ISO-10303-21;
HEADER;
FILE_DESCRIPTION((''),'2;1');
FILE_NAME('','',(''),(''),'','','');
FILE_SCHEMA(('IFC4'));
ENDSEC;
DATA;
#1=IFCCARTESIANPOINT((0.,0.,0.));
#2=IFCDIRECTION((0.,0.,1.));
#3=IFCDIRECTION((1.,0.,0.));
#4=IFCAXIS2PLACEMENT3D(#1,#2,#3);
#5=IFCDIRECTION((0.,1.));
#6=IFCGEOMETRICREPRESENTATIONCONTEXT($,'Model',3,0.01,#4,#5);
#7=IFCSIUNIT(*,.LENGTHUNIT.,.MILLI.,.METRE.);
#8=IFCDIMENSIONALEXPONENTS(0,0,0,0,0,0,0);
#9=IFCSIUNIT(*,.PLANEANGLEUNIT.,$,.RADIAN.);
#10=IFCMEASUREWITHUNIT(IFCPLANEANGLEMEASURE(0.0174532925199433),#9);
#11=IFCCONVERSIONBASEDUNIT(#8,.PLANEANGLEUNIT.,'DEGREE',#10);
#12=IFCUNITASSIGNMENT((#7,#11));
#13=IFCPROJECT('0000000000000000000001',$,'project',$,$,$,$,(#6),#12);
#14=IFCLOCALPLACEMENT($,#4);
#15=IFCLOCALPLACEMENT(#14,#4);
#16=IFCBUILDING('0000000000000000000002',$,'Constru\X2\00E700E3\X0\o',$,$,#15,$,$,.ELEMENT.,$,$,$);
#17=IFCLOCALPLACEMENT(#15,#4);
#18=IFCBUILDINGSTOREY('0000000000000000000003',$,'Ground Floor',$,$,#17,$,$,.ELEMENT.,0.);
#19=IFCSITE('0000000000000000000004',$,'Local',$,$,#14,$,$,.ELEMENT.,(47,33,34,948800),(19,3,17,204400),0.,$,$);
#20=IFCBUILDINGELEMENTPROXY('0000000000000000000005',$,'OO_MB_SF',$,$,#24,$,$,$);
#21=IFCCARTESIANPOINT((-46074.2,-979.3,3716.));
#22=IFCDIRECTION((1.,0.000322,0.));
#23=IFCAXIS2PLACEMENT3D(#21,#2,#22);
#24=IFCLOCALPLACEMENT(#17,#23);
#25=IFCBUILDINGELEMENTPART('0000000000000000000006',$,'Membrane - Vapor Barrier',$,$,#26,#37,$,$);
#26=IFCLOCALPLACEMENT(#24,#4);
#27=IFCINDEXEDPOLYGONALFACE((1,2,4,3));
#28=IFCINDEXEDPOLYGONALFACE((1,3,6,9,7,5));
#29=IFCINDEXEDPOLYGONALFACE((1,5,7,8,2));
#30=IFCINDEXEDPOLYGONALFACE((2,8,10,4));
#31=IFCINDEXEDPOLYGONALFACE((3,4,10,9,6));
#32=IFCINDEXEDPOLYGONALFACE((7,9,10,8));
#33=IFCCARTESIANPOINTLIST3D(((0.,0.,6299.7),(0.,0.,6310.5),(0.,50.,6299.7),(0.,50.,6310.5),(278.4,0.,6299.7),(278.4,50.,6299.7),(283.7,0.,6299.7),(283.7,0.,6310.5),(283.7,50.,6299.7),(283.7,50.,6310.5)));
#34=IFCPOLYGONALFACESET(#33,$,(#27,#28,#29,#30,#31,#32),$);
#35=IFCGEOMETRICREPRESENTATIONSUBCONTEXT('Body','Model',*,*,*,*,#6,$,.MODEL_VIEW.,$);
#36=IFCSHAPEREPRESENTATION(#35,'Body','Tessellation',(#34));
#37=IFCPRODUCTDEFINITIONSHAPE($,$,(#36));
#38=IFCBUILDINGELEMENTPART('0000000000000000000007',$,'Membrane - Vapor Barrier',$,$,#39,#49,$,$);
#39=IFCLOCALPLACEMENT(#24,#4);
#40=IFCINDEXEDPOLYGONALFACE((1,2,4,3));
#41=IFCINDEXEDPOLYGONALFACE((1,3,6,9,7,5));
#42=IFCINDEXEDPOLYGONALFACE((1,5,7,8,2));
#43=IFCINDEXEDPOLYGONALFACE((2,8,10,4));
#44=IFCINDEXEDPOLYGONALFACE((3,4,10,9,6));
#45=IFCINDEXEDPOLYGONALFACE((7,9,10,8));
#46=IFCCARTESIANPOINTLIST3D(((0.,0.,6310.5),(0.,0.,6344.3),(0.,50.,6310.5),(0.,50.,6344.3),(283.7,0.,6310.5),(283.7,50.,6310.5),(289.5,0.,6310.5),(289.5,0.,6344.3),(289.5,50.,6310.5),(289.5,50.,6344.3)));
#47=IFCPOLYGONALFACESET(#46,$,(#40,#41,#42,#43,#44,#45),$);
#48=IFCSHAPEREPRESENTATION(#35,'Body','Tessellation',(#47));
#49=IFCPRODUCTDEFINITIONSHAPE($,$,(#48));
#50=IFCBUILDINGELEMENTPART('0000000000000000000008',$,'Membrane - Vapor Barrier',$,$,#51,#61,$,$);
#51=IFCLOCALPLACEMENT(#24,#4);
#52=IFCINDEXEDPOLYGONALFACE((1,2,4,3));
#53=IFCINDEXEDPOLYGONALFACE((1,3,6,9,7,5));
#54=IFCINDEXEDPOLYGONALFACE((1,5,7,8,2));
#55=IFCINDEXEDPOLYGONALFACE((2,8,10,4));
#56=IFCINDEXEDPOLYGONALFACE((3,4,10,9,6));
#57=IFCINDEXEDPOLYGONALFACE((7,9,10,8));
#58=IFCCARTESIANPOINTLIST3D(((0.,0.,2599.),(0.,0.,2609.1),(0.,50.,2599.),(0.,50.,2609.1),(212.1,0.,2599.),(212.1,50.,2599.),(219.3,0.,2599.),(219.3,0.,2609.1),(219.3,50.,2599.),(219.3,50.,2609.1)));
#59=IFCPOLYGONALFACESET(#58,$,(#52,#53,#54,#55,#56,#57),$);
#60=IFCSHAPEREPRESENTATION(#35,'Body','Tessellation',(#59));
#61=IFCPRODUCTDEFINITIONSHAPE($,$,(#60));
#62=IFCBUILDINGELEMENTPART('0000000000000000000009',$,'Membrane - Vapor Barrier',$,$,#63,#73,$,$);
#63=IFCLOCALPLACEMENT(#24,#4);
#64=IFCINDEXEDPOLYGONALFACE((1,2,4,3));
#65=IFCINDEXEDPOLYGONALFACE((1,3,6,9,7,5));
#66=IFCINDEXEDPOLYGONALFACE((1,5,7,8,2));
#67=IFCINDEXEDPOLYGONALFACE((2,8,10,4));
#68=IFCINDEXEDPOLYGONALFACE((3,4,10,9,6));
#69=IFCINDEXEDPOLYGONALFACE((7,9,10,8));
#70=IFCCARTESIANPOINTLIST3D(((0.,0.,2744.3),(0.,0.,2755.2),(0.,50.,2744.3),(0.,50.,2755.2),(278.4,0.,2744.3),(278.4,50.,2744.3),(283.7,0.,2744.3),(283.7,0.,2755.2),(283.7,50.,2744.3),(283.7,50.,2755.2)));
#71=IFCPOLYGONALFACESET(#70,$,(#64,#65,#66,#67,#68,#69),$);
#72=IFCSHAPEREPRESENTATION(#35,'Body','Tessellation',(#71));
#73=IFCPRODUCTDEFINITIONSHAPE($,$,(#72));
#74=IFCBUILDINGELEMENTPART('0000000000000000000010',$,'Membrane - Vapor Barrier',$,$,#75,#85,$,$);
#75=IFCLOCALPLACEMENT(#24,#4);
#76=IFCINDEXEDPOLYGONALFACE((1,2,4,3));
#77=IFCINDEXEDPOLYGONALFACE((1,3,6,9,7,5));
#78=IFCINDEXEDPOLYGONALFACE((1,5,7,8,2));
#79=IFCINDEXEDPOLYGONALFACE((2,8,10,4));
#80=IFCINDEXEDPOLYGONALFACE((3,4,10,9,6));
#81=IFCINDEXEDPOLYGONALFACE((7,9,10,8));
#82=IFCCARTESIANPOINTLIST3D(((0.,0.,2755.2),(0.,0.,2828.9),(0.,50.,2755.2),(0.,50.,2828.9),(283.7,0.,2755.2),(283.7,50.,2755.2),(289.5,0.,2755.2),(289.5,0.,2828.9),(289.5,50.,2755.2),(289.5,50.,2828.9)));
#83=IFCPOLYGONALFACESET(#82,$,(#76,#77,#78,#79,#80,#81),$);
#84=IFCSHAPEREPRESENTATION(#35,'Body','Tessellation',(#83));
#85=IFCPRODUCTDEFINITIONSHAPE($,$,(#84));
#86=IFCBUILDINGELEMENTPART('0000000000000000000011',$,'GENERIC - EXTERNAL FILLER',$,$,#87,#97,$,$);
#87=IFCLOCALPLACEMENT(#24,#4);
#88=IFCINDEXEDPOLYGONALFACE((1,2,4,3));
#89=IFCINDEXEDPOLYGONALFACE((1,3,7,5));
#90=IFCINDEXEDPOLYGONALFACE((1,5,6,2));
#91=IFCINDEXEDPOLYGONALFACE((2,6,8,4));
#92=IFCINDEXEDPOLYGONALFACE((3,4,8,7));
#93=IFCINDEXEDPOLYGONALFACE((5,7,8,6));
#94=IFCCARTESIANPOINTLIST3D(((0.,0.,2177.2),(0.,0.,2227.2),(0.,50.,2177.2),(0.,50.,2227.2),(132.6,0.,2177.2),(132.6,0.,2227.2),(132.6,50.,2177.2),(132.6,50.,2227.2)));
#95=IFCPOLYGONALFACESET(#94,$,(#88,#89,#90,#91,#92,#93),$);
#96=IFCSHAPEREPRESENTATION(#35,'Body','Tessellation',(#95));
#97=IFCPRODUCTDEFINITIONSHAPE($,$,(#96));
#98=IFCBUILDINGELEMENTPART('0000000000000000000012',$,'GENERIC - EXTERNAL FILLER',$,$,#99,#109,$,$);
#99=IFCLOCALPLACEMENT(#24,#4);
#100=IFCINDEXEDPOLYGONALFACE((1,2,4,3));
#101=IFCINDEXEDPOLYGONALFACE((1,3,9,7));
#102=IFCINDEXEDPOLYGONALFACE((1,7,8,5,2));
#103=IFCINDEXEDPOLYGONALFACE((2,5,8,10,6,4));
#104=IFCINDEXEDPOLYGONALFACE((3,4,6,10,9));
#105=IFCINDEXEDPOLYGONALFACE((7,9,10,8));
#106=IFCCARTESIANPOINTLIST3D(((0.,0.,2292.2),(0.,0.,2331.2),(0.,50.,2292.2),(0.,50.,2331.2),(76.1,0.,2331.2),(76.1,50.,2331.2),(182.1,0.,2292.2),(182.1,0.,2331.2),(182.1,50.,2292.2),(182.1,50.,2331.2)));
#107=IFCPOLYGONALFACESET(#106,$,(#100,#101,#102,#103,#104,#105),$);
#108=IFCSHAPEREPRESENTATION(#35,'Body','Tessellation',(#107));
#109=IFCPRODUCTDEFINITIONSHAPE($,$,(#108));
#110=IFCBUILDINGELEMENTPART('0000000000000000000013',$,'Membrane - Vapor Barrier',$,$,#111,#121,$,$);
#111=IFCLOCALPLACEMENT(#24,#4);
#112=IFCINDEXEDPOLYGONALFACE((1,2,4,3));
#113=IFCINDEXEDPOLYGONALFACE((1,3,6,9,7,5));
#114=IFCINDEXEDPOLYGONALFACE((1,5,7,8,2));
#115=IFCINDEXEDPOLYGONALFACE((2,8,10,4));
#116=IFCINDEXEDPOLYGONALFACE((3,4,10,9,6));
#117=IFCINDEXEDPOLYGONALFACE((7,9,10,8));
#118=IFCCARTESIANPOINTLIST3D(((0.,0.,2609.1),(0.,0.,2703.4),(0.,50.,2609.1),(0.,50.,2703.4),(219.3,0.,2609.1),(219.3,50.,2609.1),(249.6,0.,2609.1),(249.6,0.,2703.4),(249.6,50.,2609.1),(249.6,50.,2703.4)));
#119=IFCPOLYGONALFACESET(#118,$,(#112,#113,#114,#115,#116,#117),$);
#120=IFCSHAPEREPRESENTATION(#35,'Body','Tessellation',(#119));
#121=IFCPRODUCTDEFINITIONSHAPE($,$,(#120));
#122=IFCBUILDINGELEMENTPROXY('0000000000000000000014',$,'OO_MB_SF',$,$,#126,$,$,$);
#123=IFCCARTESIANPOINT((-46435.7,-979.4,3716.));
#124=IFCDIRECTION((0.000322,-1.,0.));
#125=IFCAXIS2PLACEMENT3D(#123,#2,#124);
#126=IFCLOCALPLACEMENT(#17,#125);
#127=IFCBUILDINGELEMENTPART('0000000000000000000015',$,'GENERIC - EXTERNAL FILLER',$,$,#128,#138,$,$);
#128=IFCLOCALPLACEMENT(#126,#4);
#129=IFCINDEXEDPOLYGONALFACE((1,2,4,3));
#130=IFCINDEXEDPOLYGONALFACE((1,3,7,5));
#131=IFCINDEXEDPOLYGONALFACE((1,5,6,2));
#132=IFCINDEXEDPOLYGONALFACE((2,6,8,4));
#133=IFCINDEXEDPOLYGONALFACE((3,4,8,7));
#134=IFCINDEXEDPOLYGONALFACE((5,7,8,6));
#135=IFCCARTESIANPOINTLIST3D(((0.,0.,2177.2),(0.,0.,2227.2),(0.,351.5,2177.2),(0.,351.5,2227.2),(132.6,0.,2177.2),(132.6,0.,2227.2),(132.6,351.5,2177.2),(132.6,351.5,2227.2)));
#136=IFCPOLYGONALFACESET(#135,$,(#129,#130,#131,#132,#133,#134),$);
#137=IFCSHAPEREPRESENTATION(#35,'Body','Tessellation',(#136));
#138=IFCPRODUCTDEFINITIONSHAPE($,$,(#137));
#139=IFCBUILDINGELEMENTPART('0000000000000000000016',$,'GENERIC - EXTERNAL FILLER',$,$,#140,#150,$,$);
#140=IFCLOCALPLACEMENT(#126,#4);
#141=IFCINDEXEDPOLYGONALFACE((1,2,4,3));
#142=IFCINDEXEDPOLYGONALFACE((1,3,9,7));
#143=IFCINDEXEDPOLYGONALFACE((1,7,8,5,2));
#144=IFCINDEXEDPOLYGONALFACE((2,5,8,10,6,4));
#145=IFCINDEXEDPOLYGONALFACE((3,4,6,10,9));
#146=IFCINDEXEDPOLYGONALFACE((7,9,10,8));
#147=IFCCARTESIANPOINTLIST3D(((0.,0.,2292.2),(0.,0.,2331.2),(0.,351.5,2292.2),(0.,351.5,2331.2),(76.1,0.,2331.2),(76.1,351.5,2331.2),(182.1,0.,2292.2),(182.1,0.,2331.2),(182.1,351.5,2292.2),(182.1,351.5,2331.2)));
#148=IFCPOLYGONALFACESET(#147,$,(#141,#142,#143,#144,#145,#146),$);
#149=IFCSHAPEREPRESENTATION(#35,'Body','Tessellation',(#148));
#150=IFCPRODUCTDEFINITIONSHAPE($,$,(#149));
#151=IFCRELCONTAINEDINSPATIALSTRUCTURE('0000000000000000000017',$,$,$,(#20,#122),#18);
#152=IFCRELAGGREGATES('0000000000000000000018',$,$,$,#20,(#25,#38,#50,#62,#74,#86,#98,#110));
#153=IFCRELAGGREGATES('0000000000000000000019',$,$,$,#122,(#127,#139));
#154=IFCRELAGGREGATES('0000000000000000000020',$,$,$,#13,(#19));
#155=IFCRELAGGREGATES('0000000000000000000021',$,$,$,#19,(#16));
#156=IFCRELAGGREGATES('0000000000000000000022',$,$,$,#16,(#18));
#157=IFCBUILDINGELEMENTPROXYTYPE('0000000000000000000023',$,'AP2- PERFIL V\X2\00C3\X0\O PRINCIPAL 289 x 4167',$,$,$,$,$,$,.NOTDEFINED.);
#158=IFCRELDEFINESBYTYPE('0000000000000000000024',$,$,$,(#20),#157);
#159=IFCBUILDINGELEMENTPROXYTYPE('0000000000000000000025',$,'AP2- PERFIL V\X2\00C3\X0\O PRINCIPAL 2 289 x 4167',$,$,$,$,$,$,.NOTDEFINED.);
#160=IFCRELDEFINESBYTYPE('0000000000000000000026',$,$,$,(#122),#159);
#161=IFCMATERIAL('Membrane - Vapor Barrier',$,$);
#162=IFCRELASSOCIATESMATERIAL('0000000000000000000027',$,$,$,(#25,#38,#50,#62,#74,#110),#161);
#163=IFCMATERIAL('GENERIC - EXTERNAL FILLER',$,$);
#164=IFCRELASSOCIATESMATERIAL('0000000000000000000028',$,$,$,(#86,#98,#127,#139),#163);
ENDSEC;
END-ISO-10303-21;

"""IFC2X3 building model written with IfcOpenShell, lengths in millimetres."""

from ifc_helpers import new_model, entity, si_unit, converted_unit, direction, frame, origin_with_axes, place, context, subcontext, project, spatial, polyline, outline, extrude, material, type_object, element, aggregate, save


model = new_model("IFC2X3")

# Units and contexts
model_context = context("Model", 3, precision=0.01, world=origin_with_axes(), true_north=direction((0.0, 1.0)))
body_context = subcontext(model_context, "Body", "Model", "MODEL_VIEW")
ifc_project = project(units=[si_unit("LENGTHUNIT", "METRE", prefix="MILLI"), converted_unit("PLANEANGLEUNIT", "DEGREE", entity("IfcPlaneAngleMeasure", 0.0174532925199433), si_unit("PLANEANGLEUNIT", "RADIAN"), dimensions=[0, 0, 0, 0, 0, 0, 0])], contexts=[model_context])

# Site, building, storey
site_placement = place(None, origin_with_axes())
site = spatial("IfcSite", under=ifc_project, at=site_placement, Name="Local", CompositionType="ELEMENT", RefLatitude=(47, 33, 34, 948800), RefLongitude=(19, 3, 17, 204400), RefElevation=0.0)
building_placement = place(site_placement, origin_with_axes())
building = spatial("IfcBuilding", under=site, at=building_placement, Name="Construção", CompositionType="ELEMENT")
storey_placement = place(building_placement, origin_with_axes())
storey = spatial("IfcBuildingStorey", under=building, at=storey_placement, Name="Ground Floor", CompositionType="ELEMENT", Elevation=0.0)

# Building element proxies, building element parts
building_element_proxy_type_1 = type_object("IfcBuildingElementProxyType", Name="AP2- PERFIL VÃO PRINCIPAL 289 x 4167", PredefinedType="NOTDEFINED")
ifc_material_1 = material(Name="Membrane - Vapor Barrier")
ifc_material_2 = material(Name="GENERIC - EXTERNAL FILLER")
proxy_1_placement = place(storey_placement, frame((-46074.2, -979.3, 3716.0), z_axis=(0.0, 0.0, 1.0), x_axis=(1.0, 0.000322, 0.0)))
proxy_1 = element("IfcBuildingElementProxy", 1, at=proxy_1_placement, inside=storey, type_object=building_element_proxy_type_1, Name="OO_MB_SF")
building_element_part_1_placement = place(proxy_1_placement, origin_with_axes())
building_element_part_1 = element("IfcBuildingElementPart", 2, at=building_element_part_1_placement, material=ifc_material_1, Name="Membrane - Vapor Barrier", context=body_context, shape_type="SweptSolid", body=[
    extrude(outline(polyline([(0.0, 6299.7), (278.4, 6299.7), (283.7, 6299.7), (283.7, 6310.5), (0.0, 6310.5), (0.0, 6299.7)])), frame((0.0, 50.0, 0.0), z_axis=(0.0, -1.0, 0.0), x_axis=(1.0, 0.0, 0.0)), (0.0, 0.0, 1.0), 50.0),
])
building_element_part_2_placement = place(proxy_1_placement, origin_with_axes())
building_element_part_2 = element("IfcBuildingElementPart", 3, at=building_element_part_2_placement, material=ifc_material_1, Name="Membrane - Vapor Barrier", context=body_context, shape_type="SweptSolid", body=[
    extrude(outline(polyline([(0.0, 6310.5), (283.7, 6310.5), (289.5, 6310.5), (289.5, 6344.3), (0.0, 6344.3), (0.0, 6310.5)])), frame((0.0, 50.0, 0.0), z_axis=(0.0, -1.0, 0.0), x_axis=(1.0, 0.0, 0.0)), (0.0, 0.0, 1.0), 50.0),
])
building_element_part_3_placement = place(proxy_1_placement, origin_with_axes())
building_element_part_3 = element("IfcBuildingElementPart", 4, at=building_element_part_3_placement, material=ifc_material_1, Name="Membrane - Vapor Barrier", context=body_context, shape_type="SweptSolid", body=[
    extrude(outline(polyline([(0.0, 2599.0), (212.1, 2599.0), (219.3, 2599.0), (219.3, 2609.1), (0.0, 2609.1), (0.0, 2599.0)])), frame((0.0, 50.0, 0.0), z_axis=(0.0, -1.0, 0.0), x_axis=(1.0, 0.0, 0.0)), (0.0, 0.0, 1.0), 50.0),
])
building_element_part_4_placement = place(proxy_1_placement, origin_with_axes())
building_element_part_4 = element("IfcBuildingElementPart", 5, at=building_element_part_4_placement, material=ifc_material_1, Name="Membrane - Vapor Barrier", context=body_context, shape_type="SweptSolid", body=[
    extrude(outline(polyline([(0.0, 2744.3), (278.4, 2744.3), (283.7, 2744.3), (283.7, 2755.2), (0.0, 2755.2), (0.0, 2744.3)])), frame((0.0, 50.0, 0.0), z_axis=(0.0, -1.0, 0.0), x_axis=(1.0, 0.0, 0.0)), (0.0, 0.0, 1.0), 50.0),
])
building_element_part_5_placement = place(proxy_1_placement, origin_with_axes())
building_element_part_5 = element("IfcBuildingElementPart", 6, at=building_element_part_5_placement, material=ifc_material_1, Name="Membrane - Vapor Barrier", context=body_context, shape_type="SweptSolid", body=[
    extrude(outline(polyline([(0.0, 2755.2), (283.7, 2755.2), (289.5, 2755.2), (289.5, 2828.9), (0.0, 2828.9), (0.0, 2755.2)])), frame((0.0, 50.0, 0.0), z_axis=(0.0, -1.0, 0.0), x_axis=(1.0, 0.0, 0.0)), (0.0, 0.0, 1.0), 50.0),
])
building_element_part_6_placement = place(proxy_1_placement, origin_with_axes())
building_element_part_6 = element("IfcBuildingElementPart", 7, at=building_element_part_6_placement, material=ifc_material_2, Name="GENERIC - EXTERNAL FILLER", context=body_context, shape_type="SweptSolid", body=[
    extrude(outline(polyline([(0.0, 2227.2), (0.0, 2177.2), (132.6, 2177.2), (132.6, 2227.2), (0.0, 2227.2)])), frame((0.0, 50.0, 0.0), z_axis=(0.0, -1.0, 0.0), x_axis=(1.0, 0.0, 0.0)), (0.0, 0.0, 1.0), 50.0),
])
building_element_part_7_placement = place(proxy_1_placement, origin_with_axes())
building_element_part_7 = element("IfcBuildingElementPart", 8, at=building_element_part_7_placement, material=ifc_material_2, Name="GENERIC - EXTERNAL FILLER", context=body_context, shape_type="SweptSolid", body=[
    extrude(outline(polyline([(0.0, 2331.2), (0.0, 2292.2), (182.1, 2292.2), (182.1, 2331.2), (76.1, 2331.2), (0.0, 2331.2)])), frame((0.0, 50.0, 0.0), z_axis=(0.0, -1.0, 0.0), x_axis=(1.0, 0.0, 0.0)), (0.0, 0.0, 1.0), 50.0),
])
building_element_part_8_placement = place(proxy_1_placement, origin_with_axes())
building_element_part_8 = element("IfcBuildingElementPart", 9, at=building_element_part_8_placement, material=ifc_material_1, Name="Membrane - Vapor Barrier", context=body_context, shape_type="SweptSolid", body=[
    extrude(outline(polyline([(249.6, 2703.4), (0.0, 2703.4), (0.0, 2609.1), (219.3, 2609.1), (249.6, 2609.1), (249.6, 2703.4)])), frame((0.0, 50.0, 0.0), z_axis=(0.0, -1.0, 0.0), x_axis=(1.0, 0.0, 0.0)), (0.0, 0.0, 1.0), 50.0),
])
aggregate(proxy_1, [building_element_part_1, building_element_part_2, building_element_part_3, building_element_part_4, building_element_part_5, building_element_part_6, building_element_part_7, building_element_part_8])
building_element_proxy_type_2 = type_object("IfcBuildingElementProxyType", Name="AP2- PERFIL VÃO PRINCIPAL 2 289 x 4167", PredefinedType="NOTDEFINED")
proxy_2_placement = place(storey_placement, frame((-46435.7, -979.4, 3716.0), z_axis=(0.0, 0.0, 1.0), x_axis=(0.000322, -1.0, 0.0)))
proxy_2 = element("IfcBuildingElementProxy", 10, at=proxy_2_placement, inside=storey, type_object=building_element_proxy_type_2, Name="OO_MB_SF")
building_element_part_9_placement = place(proxy_2_placement, origin_with_axes())
building_element_part_9 = element("IfcBuildingElementPart", 11, at=building_element_part_9_placement, material=ifc_material_2, Name="GENERIC - EXTERNAL FILLER", context=body_context, shape_type="SweptSolid", body=[
    extrude(outline(polyline([(0.0, 2227.2), (0.0, 2177.2), (132.6, 2177.2), (132.6, 2227.2), (0.0, 2227.2)])), frame((0.0, 351.5, 0.0), z_axis=(0.0, -1.0, 0.0), x_axis=(1.0, 0.0, 0.0)), (0.0, 0.0, 1.0), 351.5),
])
building_element_part_10_placement = place(proxy_2_placement, origin_with_axes())
building_element_part_10 = element("IfcBuildingElementPart", 12, at=building_element_part_10_placement, material=ifc_material_2, Name="GENERIC - EXTERNAL FILLER", context=body_context, shape_type="SweptSolid", body=[
    extrude(outline(polyline([(0.0, 2331.2), (0.0, 2292.2), (182.1, 2292.2), (182.1, 2331.2), (76.1, 2331.2), (0.0, 2331.2)])), frame((0.0, 351.5, 0.0), z_axis=(0.0, -1.0, 0.0), x_axis=(1.0, 0.0, 0.0)), (0.0, 0.0, 1.0), 351.5),
])
aggregate(proxy_2, [building_element_part_9, building_element_part_10])

save(model, "model.ifc")
